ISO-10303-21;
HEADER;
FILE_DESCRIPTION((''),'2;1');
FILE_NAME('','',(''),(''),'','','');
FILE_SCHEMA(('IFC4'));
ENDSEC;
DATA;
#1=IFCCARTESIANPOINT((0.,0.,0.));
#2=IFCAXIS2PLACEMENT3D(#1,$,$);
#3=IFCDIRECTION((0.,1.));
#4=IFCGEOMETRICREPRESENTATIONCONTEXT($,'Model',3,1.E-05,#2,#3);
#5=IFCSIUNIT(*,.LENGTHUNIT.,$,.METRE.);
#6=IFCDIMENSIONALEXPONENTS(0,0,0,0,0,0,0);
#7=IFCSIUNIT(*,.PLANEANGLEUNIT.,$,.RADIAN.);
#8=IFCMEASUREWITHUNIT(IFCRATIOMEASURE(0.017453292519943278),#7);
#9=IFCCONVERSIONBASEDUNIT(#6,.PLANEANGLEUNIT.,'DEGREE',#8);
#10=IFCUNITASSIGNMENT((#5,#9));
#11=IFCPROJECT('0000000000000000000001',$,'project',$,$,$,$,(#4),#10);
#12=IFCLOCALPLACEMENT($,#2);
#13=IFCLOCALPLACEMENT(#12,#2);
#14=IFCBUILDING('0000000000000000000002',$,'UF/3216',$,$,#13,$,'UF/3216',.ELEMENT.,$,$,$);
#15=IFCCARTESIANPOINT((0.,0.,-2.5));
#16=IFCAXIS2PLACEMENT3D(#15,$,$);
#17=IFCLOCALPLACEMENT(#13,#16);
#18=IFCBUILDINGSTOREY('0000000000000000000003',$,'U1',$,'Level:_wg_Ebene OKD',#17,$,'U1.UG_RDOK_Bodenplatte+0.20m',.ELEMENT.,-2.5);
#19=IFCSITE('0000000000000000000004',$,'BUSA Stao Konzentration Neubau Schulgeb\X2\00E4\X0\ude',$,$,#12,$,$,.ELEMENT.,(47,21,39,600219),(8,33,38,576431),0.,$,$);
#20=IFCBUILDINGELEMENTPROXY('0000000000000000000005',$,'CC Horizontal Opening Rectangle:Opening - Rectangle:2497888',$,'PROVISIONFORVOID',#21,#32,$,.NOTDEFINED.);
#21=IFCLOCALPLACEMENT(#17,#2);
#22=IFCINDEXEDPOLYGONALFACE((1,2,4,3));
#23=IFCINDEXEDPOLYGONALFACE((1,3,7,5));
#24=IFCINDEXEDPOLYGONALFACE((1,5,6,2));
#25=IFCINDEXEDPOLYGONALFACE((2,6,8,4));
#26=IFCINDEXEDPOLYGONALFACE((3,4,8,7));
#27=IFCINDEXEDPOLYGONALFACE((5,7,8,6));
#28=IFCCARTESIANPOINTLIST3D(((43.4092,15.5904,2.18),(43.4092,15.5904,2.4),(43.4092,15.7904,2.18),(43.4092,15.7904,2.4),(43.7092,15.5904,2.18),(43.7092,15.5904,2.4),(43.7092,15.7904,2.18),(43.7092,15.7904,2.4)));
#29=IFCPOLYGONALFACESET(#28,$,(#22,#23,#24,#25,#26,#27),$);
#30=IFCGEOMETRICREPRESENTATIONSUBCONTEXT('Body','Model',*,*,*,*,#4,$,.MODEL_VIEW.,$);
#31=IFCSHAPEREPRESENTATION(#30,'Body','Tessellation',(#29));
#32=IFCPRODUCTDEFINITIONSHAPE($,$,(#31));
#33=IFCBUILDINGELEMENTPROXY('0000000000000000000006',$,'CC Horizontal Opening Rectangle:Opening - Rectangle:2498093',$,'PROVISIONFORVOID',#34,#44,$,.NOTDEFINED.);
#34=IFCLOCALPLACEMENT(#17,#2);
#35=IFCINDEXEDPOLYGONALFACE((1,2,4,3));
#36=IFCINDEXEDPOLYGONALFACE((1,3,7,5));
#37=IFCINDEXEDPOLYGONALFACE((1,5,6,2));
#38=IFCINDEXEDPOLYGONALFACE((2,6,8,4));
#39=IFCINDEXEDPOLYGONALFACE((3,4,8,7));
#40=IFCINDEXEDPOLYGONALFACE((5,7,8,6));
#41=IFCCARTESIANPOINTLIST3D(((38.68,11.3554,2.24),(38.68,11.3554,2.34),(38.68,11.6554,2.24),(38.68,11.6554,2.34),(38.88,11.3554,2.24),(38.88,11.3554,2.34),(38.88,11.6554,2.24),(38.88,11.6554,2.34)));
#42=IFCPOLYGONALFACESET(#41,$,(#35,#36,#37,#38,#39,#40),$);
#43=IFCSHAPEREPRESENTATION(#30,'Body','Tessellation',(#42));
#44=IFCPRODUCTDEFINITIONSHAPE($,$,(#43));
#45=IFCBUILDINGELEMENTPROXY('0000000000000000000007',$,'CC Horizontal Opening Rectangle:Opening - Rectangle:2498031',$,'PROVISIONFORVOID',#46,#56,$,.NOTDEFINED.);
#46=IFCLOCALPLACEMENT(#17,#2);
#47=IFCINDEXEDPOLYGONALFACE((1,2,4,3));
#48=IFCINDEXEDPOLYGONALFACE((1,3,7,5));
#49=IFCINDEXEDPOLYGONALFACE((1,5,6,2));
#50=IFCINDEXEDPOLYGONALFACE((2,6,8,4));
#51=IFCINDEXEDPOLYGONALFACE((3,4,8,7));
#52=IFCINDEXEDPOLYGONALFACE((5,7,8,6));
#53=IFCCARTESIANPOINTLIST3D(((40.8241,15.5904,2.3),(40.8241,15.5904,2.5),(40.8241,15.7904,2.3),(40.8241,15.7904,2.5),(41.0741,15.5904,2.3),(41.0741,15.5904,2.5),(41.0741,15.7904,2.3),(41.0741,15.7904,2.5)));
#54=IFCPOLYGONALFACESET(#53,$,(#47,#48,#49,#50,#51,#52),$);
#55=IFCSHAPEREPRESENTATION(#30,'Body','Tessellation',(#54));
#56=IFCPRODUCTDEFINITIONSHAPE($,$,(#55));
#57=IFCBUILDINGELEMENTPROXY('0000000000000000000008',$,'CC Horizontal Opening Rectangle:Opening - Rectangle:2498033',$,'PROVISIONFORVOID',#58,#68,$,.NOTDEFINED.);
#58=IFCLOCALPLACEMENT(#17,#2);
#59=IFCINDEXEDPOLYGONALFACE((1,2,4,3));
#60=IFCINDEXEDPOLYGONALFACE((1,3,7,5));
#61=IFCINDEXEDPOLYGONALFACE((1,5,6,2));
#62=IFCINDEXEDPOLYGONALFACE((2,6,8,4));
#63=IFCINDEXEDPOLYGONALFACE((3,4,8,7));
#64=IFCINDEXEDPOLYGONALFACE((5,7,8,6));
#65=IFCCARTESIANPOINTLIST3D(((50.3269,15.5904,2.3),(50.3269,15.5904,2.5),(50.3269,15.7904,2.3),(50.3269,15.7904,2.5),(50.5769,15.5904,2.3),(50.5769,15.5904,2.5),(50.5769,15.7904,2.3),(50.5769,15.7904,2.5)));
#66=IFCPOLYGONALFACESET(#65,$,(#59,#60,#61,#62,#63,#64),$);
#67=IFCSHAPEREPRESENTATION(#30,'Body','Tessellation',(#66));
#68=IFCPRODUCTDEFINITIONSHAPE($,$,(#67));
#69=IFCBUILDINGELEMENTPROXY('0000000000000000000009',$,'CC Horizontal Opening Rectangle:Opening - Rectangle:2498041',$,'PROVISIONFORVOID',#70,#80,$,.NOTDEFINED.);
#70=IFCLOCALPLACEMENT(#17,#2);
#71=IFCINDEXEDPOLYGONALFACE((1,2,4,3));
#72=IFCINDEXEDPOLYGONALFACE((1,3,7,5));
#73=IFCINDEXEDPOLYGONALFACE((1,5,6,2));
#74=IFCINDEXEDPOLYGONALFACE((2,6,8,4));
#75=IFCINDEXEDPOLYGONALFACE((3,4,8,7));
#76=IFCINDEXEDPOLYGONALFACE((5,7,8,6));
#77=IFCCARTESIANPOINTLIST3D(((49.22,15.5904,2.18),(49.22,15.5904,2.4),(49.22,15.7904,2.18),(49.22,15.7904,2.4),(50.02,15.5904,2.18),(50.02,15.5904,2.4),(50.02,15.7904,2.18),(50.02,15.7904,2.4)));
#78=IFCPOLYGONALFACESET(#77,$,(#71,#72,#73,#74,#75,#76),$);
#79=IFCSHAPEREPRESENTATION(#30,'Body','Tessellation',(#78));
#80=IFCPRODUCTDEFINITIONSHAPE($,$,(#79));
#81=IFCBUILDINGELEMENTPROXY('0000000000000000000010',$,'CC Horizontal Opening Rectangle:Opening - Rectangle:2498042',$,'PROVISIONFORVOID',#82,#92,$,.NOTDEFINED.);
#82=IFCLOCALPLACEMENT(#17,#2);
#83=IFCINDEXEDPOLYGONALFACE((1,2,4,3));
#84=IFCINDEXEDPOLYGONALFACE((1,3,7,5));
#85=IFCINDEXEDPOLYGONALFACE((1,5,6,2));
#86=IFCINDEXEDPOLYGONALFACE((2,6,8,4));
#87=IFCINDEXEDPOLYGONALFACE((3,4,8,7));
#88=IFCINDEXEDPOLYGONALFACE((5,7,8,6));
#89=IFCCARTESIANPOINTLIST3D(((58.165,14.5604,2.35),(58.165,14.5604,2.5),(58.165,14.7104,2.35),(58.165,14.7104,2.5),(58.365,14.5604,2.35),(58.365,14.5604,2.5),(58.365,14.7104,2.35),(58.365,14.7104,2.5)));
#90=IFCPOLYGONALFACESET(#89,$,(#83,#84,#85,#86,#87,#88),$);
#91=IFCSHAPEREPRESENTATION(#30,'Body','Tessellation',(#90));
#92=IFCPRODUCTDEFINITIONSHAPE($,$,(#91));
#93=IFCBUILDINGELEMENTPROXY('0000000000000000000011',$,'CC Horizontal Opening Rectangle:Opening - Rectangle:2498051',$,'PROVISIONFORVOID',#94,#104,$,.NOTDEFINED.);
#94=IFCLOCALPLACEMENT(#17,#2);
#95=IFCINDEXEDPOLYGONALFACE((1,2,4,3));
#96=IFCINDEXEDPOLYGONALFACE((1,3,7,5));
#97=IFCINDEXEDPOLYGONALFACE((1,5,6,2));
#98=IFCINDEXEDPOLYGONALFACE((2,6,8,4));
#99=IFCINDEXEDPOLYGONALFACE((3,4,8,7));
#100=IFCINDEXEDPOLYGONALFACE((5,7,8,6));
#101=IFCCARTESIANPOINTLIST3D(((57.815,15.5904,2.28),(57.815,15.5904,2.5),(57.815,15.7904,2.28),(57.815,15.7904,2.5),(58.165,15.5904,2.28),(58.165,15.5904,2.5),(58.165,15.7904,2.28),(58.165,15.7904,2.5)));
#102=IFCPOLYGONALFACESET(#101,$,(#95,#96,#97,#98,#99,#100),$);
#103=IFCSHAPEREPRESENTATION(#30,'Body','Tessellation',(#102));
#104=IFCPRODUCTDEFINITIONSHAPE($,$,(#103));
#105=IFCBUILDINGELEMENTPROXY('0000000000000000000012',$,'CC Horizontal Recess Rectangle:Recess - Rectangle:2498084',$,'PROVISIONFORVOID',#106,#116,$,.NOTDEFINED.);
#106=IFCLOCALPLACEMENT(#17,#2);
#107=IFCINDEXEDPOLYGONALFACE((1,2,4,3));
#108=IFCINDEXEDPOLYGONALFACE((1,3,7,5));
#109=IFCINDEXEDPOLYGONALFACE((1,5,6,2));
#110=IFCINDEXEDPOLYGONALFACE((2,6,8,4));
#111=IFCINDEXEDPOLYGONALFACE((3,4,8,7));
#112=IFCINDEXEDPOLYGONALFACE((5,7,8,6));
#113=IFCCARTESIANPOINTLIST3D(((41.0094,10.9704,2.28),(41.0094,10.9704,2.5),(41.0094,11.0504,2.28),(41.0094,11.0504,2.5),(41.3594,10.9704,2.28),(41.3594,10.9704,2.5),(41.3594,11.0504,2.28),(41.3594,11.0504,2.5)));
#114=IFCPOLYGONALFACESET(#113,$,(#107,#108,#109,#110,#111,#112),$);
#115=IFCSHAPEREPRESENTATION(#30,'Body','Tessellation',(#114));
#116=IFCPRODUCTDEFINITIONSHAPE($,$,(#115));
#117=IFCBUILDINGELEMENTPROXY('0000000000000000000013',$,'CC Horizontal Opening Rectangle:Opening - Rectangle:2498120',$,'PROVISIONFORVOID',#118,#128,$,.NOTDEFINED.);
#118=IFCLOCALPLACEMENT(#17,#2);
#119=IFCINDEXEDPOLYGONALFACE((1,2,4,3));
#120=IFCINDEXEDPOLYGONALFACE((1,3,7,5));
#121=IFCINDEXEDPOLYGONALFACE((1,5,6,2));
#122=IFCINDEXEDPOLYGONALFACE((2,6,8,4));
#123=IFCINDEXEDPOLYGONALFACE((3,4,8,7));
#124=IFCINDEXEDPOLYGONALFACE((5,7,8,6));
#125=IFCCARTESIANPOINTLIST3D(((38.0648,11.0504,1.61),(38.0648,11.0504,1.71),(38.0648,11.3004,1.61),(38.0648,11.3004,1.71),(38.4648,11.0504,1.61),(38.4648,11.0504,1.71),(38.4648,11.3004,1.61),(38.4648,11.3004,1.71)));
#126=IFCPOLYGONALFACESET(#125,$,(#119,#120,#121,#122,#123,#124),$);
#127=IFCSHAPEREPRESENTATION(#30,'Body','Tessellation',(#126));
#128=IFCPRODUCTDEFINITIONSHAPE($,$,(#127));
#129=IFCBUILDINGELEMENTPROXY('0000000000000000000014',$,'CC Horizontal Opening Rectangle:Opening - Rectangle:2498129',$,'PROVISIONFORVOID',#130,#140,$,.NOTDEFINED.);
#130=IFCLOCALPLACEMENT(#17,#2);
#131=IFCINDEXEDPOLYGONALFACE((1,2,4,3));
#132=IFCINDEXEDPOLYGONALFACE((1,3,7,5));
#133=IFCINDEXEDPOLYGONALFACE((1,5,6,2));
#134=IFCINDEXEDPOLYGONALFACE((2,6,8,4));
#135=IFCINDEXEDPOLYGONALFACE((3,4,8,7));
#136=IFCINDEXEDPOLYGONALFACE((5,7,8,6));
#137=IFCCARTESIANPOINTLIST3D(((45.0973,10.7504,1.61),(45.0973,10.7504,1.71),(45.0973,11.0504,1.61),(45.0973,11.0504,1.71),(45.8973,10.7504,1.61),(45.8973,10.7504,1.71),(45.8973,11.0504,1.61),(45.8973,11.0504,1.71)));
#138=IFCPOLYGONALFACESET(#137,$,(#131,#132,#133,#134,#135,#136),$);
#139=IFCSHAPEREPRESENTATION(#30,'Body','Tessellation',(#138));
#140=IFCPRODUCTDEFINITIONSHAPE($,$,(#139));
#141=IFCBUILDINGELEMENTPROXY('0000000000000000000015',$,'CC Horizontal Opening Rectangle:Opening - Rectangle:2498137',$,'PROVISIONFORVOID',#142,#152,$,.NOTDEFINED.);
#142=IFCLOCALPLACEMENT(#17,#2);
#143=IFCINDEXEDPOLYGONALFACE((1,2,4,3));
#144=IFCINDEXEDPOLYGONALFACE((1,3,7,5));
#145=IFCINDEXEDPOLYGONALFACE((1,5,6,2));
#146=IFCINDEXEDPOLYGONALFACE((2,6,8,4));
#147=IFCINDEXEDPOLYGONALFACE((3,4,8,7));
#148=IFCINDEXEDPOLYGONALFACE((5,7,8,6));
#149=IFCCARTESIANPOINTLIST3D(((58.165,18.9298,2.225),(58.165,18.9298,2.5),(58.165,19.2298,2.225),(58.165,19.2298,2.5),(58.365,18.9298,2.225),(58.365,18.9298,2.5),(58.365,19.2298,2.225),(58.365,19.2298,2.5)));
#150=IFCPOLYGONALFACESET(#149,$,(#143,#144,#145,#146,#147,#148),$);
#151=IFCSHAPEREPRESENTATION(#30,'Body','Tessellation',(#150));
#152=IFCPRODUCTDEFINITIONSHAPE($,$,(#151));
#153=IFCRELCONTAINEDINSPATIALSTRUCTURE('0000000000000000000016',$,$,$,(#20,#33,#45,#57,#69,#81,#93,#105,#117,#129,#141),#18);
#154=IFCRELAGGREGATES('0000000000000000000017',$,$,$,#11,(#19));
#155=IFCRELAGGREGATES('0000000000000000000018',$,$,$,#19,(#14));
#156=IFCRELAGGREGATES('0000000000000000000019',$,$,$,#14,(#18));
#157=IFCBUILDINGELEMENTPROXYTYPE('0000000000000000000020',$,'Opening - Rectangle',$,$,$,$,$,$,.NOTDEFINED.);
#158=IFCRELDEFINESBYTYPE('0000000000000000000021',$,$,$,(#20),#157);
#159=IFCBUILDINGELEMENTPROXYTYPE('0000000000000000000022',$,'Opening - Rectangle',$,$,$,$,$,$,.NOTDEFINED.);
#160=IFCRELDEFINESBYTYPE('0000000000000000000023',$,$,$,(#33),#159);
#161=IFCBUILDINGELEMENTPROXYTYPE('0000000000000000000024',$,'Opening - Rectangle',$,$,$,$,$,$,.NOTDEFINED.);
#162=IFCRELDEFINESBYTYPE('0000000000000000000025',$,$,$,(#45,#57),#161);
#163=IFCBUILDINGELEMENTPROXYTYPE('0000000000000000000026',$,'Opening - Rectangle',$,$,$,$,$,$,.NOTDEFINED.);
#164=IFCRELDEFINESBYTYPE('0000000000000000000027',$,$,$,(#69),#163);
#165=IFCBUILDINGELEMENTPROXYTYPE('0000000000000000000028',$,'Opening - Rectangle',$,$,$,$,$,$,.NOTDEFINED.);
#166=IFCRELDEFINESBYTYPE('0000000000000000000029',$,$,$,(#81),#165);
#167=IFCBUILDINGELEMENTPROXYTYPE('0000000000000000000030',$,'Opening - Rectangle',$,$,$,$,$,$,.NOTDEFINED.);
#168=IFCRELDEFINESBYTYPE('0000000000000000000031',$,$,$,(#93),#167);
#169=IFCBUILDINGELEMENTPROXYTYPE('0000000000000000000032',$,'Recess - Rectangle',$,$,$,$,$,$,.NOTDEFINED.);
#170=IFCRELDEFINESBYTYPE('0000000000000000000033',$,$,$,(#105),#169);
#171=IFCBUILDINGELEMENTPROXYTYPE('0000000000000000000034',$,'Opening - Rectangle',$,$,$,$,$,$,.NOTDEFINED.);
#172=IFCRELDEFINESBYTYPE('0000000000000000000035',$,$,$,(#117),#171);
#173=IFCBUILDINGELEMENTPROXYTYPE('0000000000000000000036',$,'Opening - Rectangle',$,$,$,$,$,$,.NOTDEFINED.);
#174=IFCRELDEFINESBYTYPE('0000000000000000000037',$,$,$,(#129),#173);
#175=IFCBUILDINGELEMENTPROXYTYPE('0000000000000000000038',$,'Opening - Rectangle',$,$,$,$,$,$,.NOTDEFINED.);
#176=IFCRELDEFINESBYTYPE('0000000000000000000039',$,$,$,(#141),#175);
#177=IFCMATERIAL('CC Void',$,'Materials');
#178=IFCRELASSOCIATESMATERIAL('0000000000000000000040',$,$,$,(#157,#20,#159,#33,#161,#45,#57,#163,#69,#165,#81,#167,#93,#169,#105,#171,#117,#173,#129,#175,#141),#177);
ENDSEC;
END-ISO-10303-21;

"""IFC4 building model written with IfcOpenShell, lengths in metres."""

from ifc_helpers import new_model, entity, si_unit, converted_unit, direction, frame, origin, place, context, subcontext, project, spatial, indexed_curve, outline, extrude, source, transform, mapped, material, type_object, type_shapes, element, save


model = new_model("IFC4")

# Units and contexts
model_context = context("Model", 3, precision=1e-05, world=origin(), true_north=direction((0.0, 1.0)))
body_context = subcontext(model_context, "Body", "Model", "MODEL_VIEW")
ifc_project = project(units=[si_unit("LENGTHUNIT", "METRE"), converted_unit("PLANEANGLEUNIT", "DEGREE", entity("IfcRatioMeasure", 0.017453292519943278), si_unit("PLANEANGLEUNIT", "RADIAN"), dimensions=[0, 0, 0, 0, 0, 0, 0])], contexts=[model_context])

# Site, building, storey
site_placement = place(None, origin())
site = spatial("IfcSite", under=ifc_project, at=site_placement, Name="BUSA Stao Konzentration Neubau Schulgebäude", CompositionType="ELEMENT", RefLatitude=(47, 21, 39, 600219), RefLongitude=(8, 33, 38, 576431), RefElevation=0.0)
building_placement = place(site_placement, origin())
building = spatial("IfcBuilding", under=site, at=building_placement, Name="UF/3216", LongName="UF/3216", CompositionType="ELEMENT")
storey_placement = place(building_placement, frame((0.0, 0.0, -2.5)))
storey = spatial("IfcBuildingStorey", under=building, at=storey_placement, Name="U1", ObjectType="Level:_wg_Ebene OKD", LongName="U1.UG_RDOK_Bodenplatte+0.20m", CompositionType="ELEMENT", Elevation=-2.5)

# Building element proxies
ifc_material_1 = material(Name="CC Void", Category="Materials")
building_element_proxy_type_1 = type_object("IfcBuildingElementProxyType", Name="Opening - Rectangle", PredefinedType="NOTDEFINED", material=ifc_material_1)
shared_shape_1 = source(origin(), body_context, "Body", "SweptSolid", [
    extrude(outline(indexed_curve([(-0.1, -0.15), (0.1, -0.15), (0.1, 0.15), (-0.1, 0.15), (-0.1, -0.15)], self_intersect=False)), frame((0.0, 0.0, -0.32), z_axis=(0.0, 0.0, 1.0), x_axis=(0.0, -1.0, 0.0)), (0.0, 0.0, 1.0), 0.22),
])
type_shapes(building_element_proxy_type_1, [shared_shape_1])
proxy_1_placement = place(storey_placement, frame((43.5592, 15.6904, 2.5)))
element("IfcBuildingElementProxy", 1, at=proxy_1_placement, inside=storey, type_object=building_element_proxy_type_1, material=ifc_material_1, Name="CC Horizontal Opening Rectangle:Opening - Rectangle:2497888", ObjectType="PROVISIONFORVOID", PredefinedType="NOTDEFINED", context=body_context, shape_type="MappedRepresentation", body=[
    mapped(shared_shape_1, transform((0.0, 0.0, 0.0), scale=1.0)),
])
building_element_proxy_type_2 = type_object("IfcBuildingElementProxyType", Name="Opening - Rectangle", PredefinedType="NOTDEFINED", material=ifc_material_1)
shared_shape_2 = source(origin(), body_context, "Body", "SweptSolid", [
    extrude(outline(indexed_curve([(-0.1, -0.15), (0.1, -0.15), (0.1, 0.15), (-0.1, 0.15), (-0.1, -0.15)], self_intersect=False)), frame((0.0, 0.0, -0.26), z_axis=(0.0, 0.0, 1.0), x_axis=(0.0, -1.0, 0.0)), (0.0, 0.0, 1.0), 0.1),
])
type_shapes(building_element_proxy_type_2, [shared_shape_2])
proxy_2_placement = place(storey_placement, frame((38.78, 11.5054, 2.5), z_axis=(0.0, 0.0, 1.0), x_axis=(0.0, 1.0, 0.0)))
element("IfcBuildingElementProxy", 2, at=proxy_2_placement, inside=storey, type_object=building_element_proxy_type_2, material=ifc_material_1, Name="CC Horizontal Opening Rectangle:Opening - Rectangle:2498093", ObjectType="PROVISIONFORVOID", PredefinedType="NOTDEFINED", context=body_context, shape_type="MappedRepresentation", body=[
    mapped(shared_shape_2, transform((0.0, 0.0, 0.0), scale=1.0)),
])
building_element_proxy_type_3 = type_object("IfcBuildingElementProxyType", Name="Opening - Rectangle", PredefinedType="NOTDEFINED", material=ifc_material_1)
shared_shape_3 = source(origin(), body_context, "Body", "SweptSolid", [
    extrude(outline(indexed_curve([(-0.1, -0.125), (0.1, -0.125), (0.1, 0.125), (-0.1, 0.125), (-0.1, -0.125)], self_intersect=False)), frame((0.0, 0.0, -0.2), z_axis=(0.0, 0.0, 1.0), x_axis=(0.0, -1.0, 0.0)), (0.0, 0.0, 1.0), 0.2),
])
type_shapes(building_element_proxy_type_3, [shared_shape_3])
for number, where, name in (
    (3, (40.9491, 15.6904, 2.5), "CC Horizontal Opening Rectangle:Opening - Rectangle:2498031"),
    (4, (50.4519, 15.6904, 2.5), "CC Horizontal Opening Rectangle:Opening - Rectangle:2498033"),
):
    element("IfcBuildingElementProxy", number, at=place(storey_placement, frame(where)), inside=storey, type_object=building_element_proxy_type_3, material=ifc_material_1, Name=name, ObjectType="PROVISIONFORVOID", PredefinedType="NOTDEFINED", context=body_context, shape_type="MappedRepresentation", body=[
        mapped(shared_shape_3, transform((0.0, 0.0, 0.0), scale=1.0)),
    ])
building_element_proxy_type_4 = type_object("IfcBuildingElementProxyType", Name="Opening - Rectangle", PredefinedType="NOTDEFINED", material=ifc_material_1)
shared_shape_4 = source(origin(), body_context, "Body", "SweptSolid", [
    extrude(outline(indexed_curve([(-0.1, -0.4), (0.1, -0.4), (0.1, 0.4), (-0.1, 0.4), (-0.1, -0.4)], self_intersect=False)), frame((0.0, 0.0, -0.32), z_axis=(0.0, 0.0, 1.0), x_axis=(0.0, -1.0, 0.0)), (0.0, 0.0, 1.0), 0.22),
])
type_shapes(building_element_proxy_type_4, [shared_shape_4])
proxy_3_placement = place(storey_placement, frame((49.62, 15.6904, 2.5)))
element("IfcBuildingElementProxy", 5, at=proxy_3_placement, inside=storey, type_object=building_element_proxy_type_4, material=ifc_material_1, Name="CC Horizontal Opening Rectangle:Opening - Rectangle:2498041", ObjectType="PROVISIONFORVOID", PredefinedType="NOTDEFINED", context=body_context, shape_type="MappedRepresentation", body=[
    mapped(shared_shape_4, transform((0.0, 0.0, 0.0), scale=1.0)),
])
building_element_proxy_type_5 = type_object("IfcBuildingElementProxyType", Name="Opening - Rectangle", PredefinedType="NOTDEFINED", material=ifc_material_1)
shared_shape_5 = source(origin(), body_context, "Body", "SweptSolid", [
    extrude(outline(indexed_curve([(-0.1, -0.075), (0.1, -0.075), (0.1, 0.075), (-0.1, 0.075), (-0.1, -0.075)], self_intersect=False)), frame((0.0, 0.0, -0.15), z_axis=(0.0, 0.0, 1.0), x_axis=(0.0, -1.0, 0.0)), (0.0, 0.0, 1.0), 0.15),
])
type_shapes(building_element_proxy_type_5, [shared_shape_5])
proxy_4_placement = place(storey_placement, frame((58.265, 14.6354, 2.5), z_axis=(0.0, 0.0, 1.0), x_axis=(0.0, 1.0, 0.0)))
element("IfcBuildingElementProxy", 6, at=proxy_4_placement, inside=storey, type_object=building_element_proxy_type_5, material=ifc_material_1, Name="CC Horizontal Opening Rectangle:Opening - Rectangle:2498042", ObjectType="PROVISIONFORVOID", PredefinedType="NOTDEFINED", context=body_context, shape_type="MappedRepresentation", body=[
    mapped(shared_shape_5, transform((0.0, 0.0, 0.0), scale=1.0)),
])
building_element_proxy_type_6 = type_object("IfcBuildingElementProxyType", Name="Opening - Rectangle", PredefinedType="NOTDEFINED", material=ifc_material_1)
shared_shape_6 = source(origin(), body_context, "Body", "SweptSolid", [
    extrude(outline(indexed_curve([(-0.1, -0.175), (0.1, -0.175), (0.1, 0.175), (-0.1, 0.175), (-0.1, -0.175)], self_intersect=False)), frame((0.0, 0.0, -0.22), z_axis=(0.0, 0.0, 1.0), x_axis=(0.0, -1.0, 0.0)), (0.0, 0.0, 1.0), 0.22),
])
type_shapes(building_element_proxy_type_6, [shared_shape_6])
proxy_5_placement = place(storey_placement, frame((57.99, 15.6904, 2.5)))
element("IfcBuildingElementProxy", 7, at=proxy_5_placement, inside=storey, type_object=building_element_proxy_type_6, material=ifc_material_1, Name="CC Horizontal Opening Rectangle:Opening - Rectangle:2498051", ObjectType="PROVISIONFORVOID", PredefinedType="NOTDEFINED", context=body_context, shape_type="MappedRepresentation", body=[
    mapped(shared_shape_6, transform((0.0, 0.0, 0.0), scale=1.0)),
])
building_element_proxy_type_7 = type_object("IfcBuildingElementProxyType", Name="Recess - Rectangle", PredefinedType="NOTDEFINED", material=ifc_material_1)
shared_shape_7 = source(origin(), body_context, "Body", "SweptSolid", [
    extrude(outline(indexed_curve([(-0.04, -0.175), (0.04, -0.175), (0.04, 0.175), (-0.04, 0.175), (-0.04, -0.175)], self_intersect=False)), frame((0.0, 0.0, -0.22), z_axis=(0.0, 0.0, 1.0), x_axis=(0.0, -1.0, 0.0)), (0.0, 0.0, 1.0), 0.22),
])
type_shapes(building_element_proxy_type_7, [shared_shape_7])
proxy_6_placement = place(storey_placement, frame((41.1844, 11.0104, 2.5)))
element("IfcBuildingElementProxy", 8, at=proxy_6_placement, inside=storey, type_object=building_element_proxy_type_7, material=ifc_material_1, Name="CC Horizontal Recess Rectangle:Recess - Rectangle:2498084", ObjectType="PROVISIONFORVOID", PredefinedType="NOTDEFINED", context=body_context, shape_type="MappedRepresentation", body=[
    mapped(shared_shape_7, transform((0.0, 0.0, 0.0), scale=1.0)),
])
building_element_proxy_type_8 = type_object("IfcBuildingElementProxyType", Name="Opening - Rectangle", PredefinedType="NOTDEFINED", material=ifc_material_1)
shared_shape_8 = source(origin(), body_context, "Body", "SweptSolid", [
    extrude(outline(indexed_curve([(-0.125, -0.2), (0.125, -0.2), (0.125, 0.2), (-0.125, 0.2), (-0.125, -0.2)], self_intersect=False)), frame((0.0, 0.0, -0.89), z_axis=(0.0, 0.0, 1.0), x_axis=(0.0, -1.0, 0.0)), (0.0, 0.0, 1.0), 0.1),
])
type_shapes(building_element_proxy_type_8, [shared_shape_8])
proxy_7_placement = place(storey_placement, frame((38.2648, 11.1754, 2.5)))
element("IfcBuildingElementProxy", 9, at=proxy_7_placement, inside=storey, type_object=building_element_proxy_type_8, material=ifc_material_1, Name="CC Horizontal Opening Rectangle:Opening - Rectangle:2498120", ObjectType="PROVISIONFORVOID", PredefinedType="NOTDEFINED", context=body_context, shape_type="MappedRepresentation", body=[
    mapped(shared_shape_8, transform((0.0, 0.0, 0.0), scale=1.0)),
])
building_element_proxy_type_9 = type_object("IfcBuildingElementProxyType", Name="Opening - Rectangle", PredefinedType="NOTDEFINED", material=ifc_material_1)
shared_shape_9 = source(origin(), body_context, "Body", "SweptSolid", [
    extrude(outline(indexed_curve([(-0.15, -0.4), (0.15, -0.4), (0.15, 0.4), (-0.15, 0.4), (-0.15, -0.4)], self_intersect=False)), frame((0.0, 0.0, -0.89), z_axis=(0.0, 0.0, 1.0), x_axis=(0.0, -1.0, 0.0)), (0.0, 0.0, 1.0), 0.1),
])
type_shapes(building_element_proxy_type_9, [shared_shape_9])
proxy_8_placement = place(storey_placement, frame((45.4973, 10.9004, 2.5)))
element("IfcBuildingElementProxy", 10, at=proxy_8_placement, inside=storey, type_object=building_element_proxy_type_9, material=ifc_material_1, Name="CC Horizontal Opening Rectangle:Opening - Rectangle:2498129", ObjectType="PROVISIONFORVOID", PredefinedType="NOTDEFINED", context=body_context, shape_type="MappedRepresentation", body=[
    mapped(shared_shape_9, transform((0.0, 0.0, 0.0), scale=1.0)),
])
building_element_proxy_type_10 = type_object("IfcBuildingElementProxyType", Name="Opening - Rectangle", PredefinedType="NOTDEFINED", material=ifc_material_1)
shared_shape_10 = source(origin(), body_context, "Body", "SweptSolid", [
    extrude(outline(indexed_curve([(-0.1, -0.15), (0.1, -0.15), (0.1, 0.15), (-0.1, 0.15), (-0.1, -0.15)], self_intersect=False)), frame((0.0, 0.0, -0.275), z_axis=(0.0, 0.0, 1.0), x_axis=(0.0, -1.0, 0.0)), (0.0, 0.0, 1.0), 0.275),
])
type_shapes(building_element_proxy_type_10, [shared_shape_10])
proxy_9_placement = place(storey_placement, frame((58.265, 19.0798, 2.5), z_axis=(0.0, 0.0, 1.0), x_axis=(0.0, 1.0, 0.0)))
element("IfcBuildingElementProxy", 11, at=proxy_9_placement, inside=storey, type_object=building_element_proxy_type_10, material=ifc_material_1, Name="CC Horizontal Opening Rectangle:Opening - Rectangle:2498137", ObjectType="PROVISIONFORVOID", PredefinedType="NOTDEFINED", context=body_context, shape_type="MappedRepresentation", body=[
    mapped(shared_shape_10, transform((0.0, 0.0, 0.0), scale=1.0)),
])

save(model, "model.ifc")
